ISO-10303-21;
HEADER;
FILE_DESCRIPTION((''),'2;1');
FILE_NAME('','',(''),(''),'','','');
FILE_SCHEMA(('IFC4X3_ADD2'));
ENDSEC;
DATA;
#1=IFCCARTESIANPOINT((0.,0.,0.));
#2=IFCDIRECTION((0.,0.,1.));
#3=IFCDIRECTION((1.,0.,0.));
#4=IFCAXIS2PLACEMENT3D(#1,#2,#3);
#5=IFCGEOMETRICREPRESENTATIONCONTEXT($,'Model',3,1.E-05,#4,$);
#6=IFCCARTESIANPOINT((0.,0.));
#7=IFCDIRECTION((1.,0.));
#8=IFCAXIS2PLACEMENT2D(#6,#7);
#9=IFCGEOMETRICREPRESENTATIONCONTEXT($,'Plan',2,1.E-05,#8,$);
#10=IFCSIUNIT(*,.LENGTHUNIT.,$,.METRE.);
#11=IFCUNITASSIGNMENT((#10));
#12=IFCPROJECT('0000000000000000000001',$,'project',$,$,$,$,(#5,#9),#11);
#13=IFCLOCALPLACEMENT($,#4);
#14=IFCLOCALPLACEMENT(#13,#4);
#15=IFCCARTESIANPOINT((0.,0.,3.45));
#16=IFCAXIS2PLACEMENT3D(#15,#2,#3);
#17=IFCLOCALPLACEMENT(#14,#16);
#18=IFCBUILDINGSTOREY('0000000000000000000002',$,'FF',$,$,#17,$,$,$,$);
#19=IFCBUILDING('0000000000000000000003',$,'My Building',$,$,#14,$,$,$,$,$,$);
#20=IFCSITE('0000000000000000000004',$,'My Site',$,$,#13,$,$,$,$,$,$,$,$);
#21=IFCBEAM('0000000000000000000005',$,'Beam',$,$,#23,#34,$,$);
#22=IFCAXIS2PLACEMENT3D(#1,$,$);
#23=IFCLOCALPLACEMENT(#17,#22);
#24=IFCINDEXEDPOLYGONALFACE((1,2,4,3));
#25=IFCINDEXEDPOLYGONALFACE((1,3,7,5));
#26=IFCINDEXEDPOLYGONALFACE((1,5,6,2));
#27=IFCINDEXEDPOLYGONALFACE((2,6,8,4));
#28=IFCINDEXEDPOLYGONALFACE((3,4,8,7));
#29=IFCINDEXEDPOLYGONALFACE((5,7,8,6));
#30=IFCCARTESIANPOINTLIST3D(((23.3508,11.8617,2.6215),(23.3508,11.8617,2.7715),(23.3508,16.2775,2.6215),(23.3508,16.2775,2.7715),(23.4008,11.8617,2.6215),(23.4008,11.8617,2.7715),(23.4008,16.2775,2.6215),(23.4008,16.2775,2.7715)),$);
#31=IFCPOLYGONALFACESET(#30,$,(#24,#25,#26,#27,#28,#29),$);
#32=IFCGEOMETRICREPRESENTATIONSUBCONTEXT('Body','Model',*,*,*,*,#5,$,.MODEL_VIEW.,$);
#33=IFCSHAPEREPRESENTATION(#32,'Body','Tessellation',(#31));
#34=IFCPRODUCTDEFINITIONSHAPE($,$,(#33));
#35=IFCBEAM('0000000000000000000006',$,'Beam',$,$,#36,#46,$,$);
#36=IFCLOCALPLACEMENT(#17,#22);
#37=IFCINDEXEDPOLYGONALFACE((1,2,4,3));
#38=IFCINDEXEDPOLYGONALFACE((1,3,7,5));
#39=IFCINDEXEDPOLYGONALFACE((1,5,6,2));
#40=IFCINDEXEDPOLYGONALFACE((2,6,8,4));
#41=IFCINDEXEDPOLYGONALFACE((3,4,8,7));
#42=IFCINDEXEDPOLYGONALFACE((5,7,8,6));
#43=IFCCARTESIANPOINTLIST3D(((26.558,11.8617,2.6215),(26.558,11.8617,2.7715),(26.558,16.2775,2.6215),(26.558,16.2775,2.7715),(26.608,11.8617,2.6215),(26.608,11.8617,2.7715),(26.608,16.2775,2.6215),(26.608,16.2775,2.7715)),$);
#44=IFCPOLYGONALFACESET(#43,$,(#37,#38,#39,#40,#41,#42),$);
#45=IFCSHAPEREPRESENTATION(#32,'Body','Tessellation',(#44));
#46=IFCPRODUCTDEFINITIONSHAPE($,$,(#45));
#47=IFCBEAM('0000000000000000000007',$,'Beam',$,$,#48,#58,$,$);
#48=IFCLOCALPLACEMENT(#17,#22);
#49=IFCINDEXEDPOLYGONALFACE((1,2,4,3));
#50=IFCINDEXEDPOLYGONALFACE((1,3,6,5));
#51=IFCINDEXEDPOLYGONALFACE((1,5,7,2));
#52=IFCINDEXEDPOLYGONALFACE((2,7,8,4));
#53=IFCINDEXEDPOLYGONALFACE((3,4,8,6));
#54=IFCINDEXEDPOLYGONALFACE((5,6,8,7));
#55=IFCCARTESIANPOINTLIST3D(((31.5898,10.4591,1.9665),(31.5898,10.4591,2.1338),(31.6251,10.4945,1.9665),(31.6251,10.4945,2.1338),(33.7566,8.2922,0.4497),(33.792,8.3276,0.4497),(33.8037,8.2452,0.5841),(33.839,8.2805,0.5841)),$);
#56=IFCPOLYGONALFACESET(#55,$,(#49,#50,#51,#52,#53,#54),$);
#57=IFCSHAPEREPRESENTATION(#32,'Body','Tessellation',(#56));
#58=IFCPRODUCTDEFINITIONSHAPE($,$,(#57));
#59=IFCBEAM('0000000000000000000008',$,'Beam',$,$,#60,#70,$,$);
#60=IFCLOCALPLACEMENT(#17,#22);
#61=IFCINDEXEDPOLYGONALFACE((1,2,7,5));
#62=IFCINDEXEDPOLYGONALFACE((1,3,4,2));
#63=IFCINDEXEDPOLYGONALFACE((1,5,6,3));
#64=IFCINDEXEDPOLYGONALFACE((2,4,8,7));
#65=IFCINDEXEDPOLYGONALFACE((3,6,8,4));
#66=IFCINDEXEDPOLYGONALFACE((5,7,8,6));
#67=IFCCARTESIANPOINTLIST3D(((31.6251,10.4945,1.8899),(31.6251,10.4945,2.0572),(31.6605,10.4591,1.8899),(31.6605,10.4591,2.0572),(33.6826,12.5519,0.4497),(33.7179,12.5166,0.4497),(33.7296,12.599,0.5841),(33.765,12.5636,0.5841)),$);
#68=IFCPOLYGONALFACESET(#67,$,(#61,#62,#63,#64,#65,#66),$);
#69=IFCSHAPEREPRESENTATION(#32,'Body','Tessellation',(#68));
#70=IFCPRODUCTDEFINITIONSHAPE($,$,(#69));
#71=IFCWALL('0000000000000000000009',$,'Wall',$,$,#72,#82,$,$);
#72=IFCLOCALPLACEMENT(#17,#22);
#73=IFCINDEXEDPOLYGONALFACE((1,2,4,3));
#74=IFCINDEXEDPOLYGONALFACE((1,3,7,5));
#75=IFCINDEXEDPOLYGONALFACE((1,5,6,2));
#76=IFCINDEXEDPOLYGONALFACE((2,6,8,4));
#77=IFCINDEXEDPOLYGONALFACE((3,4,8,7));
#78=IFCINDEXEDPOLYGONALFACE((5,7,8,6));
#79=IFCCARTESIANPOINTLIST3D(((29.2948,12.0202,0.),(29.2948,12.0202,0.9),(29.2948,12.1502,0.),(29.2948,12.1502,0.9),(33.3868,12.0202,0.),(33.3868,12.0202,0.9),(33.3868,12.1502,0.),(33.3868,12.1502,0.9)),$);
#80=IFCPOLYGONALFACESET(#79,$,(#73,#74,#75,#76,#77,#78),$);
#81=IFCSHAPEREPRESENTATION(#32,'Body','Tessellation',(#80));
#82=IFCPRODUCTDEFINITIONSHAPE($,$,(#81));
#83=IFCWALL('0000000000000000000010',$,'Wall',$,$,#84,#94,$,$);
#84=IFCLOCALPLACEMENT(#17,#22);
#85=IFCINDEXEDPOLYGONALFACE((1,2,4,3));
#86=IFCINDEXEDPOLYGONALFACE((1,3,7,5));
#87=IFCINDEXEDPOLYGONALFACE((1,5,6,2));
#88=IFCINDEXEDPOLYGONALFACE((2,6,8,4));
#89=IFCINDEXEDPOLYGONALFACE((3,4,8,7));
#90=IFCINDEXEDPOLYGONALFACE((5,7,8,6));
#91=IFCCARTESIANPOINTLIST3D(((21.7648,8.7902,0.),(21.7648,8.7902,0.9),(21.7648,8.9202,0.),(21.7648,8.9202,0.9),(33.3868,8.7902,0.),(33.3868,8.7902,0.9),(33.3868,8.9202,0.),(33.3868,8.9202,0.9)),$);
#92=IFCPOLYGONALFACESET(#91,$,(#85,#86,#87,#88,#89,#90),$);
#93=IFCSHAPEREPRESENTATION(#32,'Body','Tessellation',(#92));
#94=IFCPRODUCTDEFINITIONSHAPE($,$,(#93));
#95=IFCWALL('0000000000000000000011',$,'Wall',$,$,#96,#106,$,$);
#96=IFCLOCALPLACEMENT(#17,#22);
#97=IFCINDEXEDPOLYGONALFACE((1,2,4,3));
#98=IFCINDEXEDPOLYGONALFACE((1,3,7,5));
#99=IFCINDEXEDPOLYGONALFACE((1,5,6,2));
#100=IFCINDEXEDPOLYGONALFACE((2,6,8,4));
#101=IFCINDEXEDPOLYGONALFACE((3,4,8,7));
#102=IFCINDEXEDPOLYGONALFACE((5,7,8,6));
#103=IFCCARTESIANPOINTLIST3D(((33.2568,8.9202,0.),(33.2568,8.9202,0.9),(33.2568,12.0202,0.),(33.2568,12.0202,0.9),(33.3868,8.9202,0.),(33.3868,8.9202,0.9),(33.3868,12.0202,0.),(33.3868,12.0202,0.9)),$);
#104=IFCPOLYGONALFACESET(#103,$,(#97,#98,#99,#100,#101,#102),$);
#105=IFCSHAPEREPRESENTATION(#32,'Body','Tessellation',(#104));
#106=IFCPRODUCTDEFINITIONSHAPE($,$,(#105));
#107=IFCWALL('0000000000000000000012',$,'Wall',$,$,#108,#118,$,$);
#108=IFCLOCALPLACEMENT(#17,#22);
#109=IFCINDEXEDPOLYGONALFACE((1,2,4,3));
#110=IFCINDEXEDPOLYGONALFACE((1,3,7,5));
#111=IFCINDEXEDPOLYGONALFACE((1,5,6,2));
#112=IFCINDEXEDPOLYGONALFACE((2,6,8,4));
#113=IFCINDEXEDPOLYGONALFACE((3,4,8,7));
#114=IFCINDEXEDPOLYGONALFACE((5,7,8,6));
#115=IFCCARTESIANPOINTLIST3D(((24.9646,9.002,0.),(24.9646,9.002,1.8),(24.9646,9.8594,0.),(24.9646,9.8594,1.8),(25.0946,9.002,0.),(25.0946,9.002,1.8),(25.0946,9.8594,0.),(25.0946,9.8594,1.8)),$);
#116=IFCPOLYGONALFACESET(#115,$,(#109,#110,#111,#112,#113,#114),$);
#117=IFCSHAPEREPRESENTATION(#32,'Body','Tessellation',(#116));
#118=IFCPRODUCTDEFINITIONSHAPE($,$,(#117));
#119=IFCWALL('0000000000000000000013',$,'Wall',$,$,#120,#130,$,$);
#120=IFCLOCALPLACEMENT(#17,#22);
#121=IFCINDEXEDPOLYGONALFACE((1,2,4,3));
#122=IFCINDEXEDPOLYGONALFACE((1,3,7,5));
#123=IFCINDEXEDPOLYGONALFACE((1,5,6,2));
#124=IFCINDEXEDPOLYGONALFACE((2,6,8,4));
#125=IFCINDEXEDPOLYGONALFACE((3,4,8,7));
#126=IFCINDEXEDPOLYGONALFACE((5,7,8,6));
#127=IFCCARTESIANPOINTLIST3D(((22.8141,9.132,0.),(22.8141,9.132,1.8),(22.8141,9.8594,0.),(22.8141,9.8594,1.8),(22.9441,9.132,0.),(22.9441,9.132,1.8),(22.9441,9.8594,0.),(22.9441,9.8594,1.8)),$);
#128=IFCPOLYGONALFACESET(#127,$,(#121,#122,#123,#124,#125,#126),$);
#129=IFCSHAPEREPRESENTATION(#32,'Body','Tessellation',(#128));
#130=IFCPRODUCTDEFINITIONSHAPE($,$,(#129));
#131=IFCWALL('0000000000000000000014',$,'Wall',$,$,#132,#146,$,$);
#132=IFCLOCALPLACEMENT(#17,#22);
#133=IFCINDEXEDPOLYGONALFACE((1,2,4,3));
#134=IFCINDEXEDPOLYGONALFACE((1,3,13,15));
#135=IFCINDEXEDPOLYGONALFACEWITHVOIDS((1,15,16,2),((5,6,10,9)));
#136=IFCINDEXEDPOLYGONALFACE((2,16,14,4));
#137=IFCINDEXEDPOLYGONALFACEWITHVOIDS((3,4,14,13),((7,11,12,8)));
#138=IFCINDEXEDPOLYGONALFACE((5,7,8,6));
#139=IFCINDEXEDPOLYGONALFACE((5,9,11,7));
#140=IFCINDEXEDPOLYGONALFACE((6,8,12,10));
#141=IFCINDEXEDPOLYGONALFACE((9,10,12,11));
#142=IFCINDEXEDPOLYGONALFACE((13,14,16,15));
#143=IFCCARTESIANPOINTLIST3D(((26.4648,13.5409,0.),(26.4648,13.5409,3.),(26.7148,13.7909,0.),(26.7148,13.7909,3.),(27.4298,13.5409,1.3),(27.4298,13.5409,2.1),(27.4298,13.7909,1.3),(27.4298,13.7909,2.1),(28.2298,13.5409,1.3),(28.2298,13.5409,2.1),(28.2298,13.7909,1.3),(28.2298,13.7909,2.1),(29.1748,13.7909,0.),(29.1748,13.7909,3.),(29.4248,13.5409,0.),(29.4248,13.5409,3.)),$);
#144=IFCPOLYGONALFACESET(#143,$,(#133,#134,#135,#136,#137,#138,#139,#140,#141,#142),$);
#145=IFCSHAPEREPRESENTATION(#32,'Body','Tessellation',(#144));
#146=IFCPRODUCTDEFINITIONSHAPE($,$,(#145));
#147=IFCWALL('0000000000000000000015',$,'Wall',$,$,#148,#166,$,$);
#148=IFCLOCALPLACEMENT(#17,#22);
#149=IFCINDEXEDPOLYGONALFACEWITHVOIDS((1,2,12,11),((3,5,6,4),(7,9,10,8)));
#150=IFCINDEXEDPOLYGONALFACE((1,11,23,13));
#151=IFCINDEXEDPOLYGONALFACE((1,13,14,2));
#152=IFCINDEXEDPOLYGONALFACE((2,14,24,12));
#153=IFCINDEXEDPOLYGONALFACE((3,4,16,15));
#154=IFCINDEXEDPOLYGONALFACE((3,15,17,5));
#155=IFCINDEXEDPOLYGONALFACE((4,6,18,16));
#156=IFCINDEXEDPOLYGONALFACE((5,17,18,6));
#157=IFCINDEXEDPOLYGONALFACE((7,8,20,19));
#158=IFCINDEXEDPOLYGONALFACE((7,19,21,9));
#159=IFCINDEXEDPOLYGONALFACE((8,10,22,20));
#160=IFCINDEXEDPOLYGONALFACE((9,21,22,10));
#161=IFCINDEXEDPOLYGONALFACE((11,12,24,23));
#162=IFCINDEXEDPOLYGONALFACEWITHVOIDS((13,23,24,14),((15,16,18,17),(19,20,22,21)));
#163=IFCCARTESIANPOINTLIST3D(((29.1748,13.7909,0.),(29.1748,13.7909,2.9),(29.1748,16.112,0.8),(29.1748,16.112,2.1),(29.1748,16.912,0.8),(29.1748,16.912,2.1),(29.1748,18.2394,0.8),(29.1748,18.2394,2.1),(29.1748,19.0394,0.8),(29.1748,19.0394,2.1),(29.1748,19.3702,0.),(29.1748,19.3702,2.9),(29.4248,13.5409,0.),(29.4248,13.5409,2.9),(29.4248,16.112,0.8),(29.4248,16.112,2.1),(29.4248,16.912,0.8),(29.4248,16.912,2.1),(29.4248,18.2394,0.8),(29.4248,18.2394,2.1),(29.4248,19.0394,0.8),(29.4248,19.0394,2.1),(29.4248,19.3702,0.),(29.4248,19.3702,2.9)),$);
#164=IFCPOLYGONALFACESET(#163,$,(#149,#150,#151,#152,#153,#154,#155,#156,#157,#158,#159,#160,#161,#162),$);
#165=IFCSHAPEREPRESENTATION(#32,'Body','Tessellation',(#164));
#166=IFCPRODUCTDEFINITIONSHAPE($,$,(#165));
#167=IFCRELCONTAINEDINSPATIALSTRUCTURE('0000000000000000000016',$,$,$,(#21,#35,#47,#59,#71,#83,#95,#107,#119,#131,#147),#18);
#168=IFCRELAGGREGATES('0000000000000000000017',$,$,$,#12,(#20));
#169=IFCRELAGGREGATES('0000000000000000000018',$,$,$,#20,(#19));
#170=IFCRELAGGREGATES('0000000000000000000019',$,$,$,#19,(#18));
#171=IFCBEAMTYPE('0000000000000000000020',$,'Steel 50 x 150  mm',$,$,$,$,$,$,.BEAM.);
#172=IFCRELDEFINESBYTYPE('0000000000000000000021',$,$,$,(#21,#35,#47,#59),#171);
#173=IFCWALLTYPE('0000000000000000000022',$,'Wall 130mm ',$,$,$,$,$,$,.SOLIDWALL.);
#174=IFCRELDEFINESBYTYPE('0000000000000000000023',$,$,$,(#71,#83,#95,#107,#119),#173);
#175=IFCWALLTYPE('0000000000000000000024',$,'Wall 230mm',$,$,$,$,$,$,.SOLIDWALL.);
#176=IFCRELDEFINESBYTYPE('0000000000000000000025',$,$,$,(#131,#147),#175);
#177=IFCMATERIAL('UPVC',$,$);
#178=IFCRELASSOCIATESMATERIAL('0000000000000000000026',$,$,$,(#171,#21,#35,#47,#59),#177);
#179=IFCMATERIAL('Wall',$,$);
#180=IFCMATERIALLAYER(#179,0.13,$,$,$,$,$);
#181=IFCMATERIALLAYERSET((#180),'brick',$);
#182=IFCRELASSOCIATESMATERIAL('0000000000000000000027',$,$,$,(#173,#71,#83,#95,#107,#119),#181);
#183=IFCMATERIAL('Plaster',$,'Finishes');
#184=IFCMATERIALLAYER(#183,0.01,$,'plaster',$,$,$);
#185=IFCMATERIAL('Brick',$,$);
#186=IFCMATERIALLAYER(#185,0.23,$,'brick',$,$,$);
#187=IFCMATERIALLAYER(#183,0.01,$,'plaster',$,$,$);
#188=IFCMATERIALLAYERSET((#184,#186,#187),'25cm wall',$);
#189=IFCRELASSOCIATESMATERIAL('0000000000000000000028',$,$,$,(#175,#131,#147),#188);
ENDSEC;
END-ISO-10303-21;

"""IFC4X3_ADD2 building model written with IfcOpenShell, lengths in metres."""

from ifc_helpers import new_model, si_unit, frame, origin_with_axes, origin_2d_with_axis, place, context, subcontext, project, spatial, line, indexed_curve, rectangle, outline, extrude, clip, halfspace, source, transform, mapped, material, layer, layer_set, layer_usage, material_profile, profile_set, profile_usage, type_object, element, save


model = new_model("IFC4X3_ADD2")

# Units and contexts
model_context = context("Model", 3, precision=1e-05, world=origin_with_axes())
plan_context = context("Plan", 2, precision=1e-05, world=origin_2d_with_axis())
body_context_1 = subcontext(model_context, "Body", "Model", "MODEL_VIEW")
ifc_project = project(units=[si_unit("LENGTHUNIT", "METRE")], contexts=[model_context, plan_context])

# Site, building, storey
site_placement = place(None, origin_with_axes())
site = spatial("IfcSite", under=ifc_project, at=site_placement, Name="My Site")
building_placement = place(site_placement, origin_with_axes())
building = spatial("IfcBuilding", under=site, at=building_placement, Name="My Building")
storey_placement = place(building_placement, frame((0.0, 0.0, 3.45), z_axis=(0.0, 0.0, 1.0), x_axis=(1.0, 0.0, 0.0)))
storey = spatial("IfcBuildingStorey", under=building, at=storey_placement, Name="FF")

# Beams
ifc_material_1 = material(Name="UPVC")
ifc_material_profile = material_profile(ifc_material_1, rectangle(XDim=0.05, YDim=0.15))
ifc_profile_set = profile_set([ifc_material_profile])
ifc_profile_usage_1 = profile_usage(ifc_profile_set)
beam_type = type_object("IfcBeamType", Name="Steel 50 x 150  mm", PredefinedType="BEAM", material=ifc_profile_set)
beam_1_placement = place(storey_placement, frame((23.3758, 11.8617, 2.6965), z_axis=(0.0, 1.0, 0.0), x_axis=(-1.0, 0.0, 0.0)))
element("IfcBeam", 1, at=beam_1_placement, inside=storey, type_object=beam_type, material=ifc_profile_usage_1, Name="Beam", context=body_context_1, shape_type="SweptSolid", body=[
    extrude(rectangle(XDim=0.05, YDim=0.15), origin_with_axes(), (0.0, 0.0, 1.0), 4.4158),
])
ifc_profile_usage_2 = profile_usage(ifc_profile_set)
beam_2_placement = place(storey_placement, frame((26.583, 11.8617, 2.6965), z_axis=(0.0, 1.0, 0.0), x_axis=(-1.0, 0.0, 0.0)))
element("IfcBeam", 2, at=beam_2_placement, inside=storey, type_object=beam_type, material=ifc_profile_usage_2, Name="Beam", context=body_context_1, shape_type="SweptSolid", body=[
    extrude(rectangle(XDim=0.05, YDim=0.15), origin_with_axes(), (0.0, 0.0, 1.0), 4.4158),
])
ifc_profile_usage_3 = profile_usage(ifc_profile_set)
beam_3_placement = place(storey_placement, frame((33.7978, 8.2864, 0.5169), z_axis=(-0.633729, 0.633729, 0.443593), x_axis=(-0.707107, -0.707107, 0.0)))
element("IfcBeam", 3, at=beam_3_placement, inside=storey, type_object=beam_type, material=ifc_profile_usage_3, Name="Beam", context=body_context_1, shape_type="Clipping", body=[
    clip(extrude(rectangle(XDim=0.05, YDim=0.15), origin_with_axes(), (0.0, 0.0, 1.0), 3.6064), halfspace(frame((-2.9679, -1.3741, 2.7762), z_axis=(0.0, -0.443593, 0.896228), x_axis=(-1.0, -0.000001, 0.0)), False)),
])
ifc_profile_usage_4 = profile_usage(ifc_profile_set)
beam_4_placement = place(storey_placement, frame((33.7238, 12.5578, 0.5169), z_axis=(-0.633729, -0.633729, 0.443593), x_axis=(0.707107, -0.707107, 0.0)))
element("IfcBeam", 4, at=beam_4_placement, inside=storey, type_object=beam_type, material=ifc_profile_usage_4, Name="Beam", context=body_context_1, shape_type="Clipping", body=[
    clip(extrude(rectangle(XDim=0.05, YDim=0.15), origin_with_axes(), (0.0, 0.0, 1.0), 3.4337), halfspace(frame((3.0727, -1.3055, 2.6376), z_axis=(0.0, -0.443593, 0.896228), x_axis=(-1.0, 0.0, 0.0)), False)),
])

# Walls
ifc_material_2 = material(Name="Wall")
ifc_layer_1 = layer(ifc_material_2, 0.13)
ifc_layer_set_1 = layer_set([ifc_layer_1], Name="brick")
ifc_layer_usage_1 = layer_usage(ifc_layer_set_1, "AXIS2", "POSITIVE", 0.0)
wall_type_1 = type_object("IfcWallType", Name="Wall 130mm ", PredefinedType="SOLIDWALL", material=ifc_layer_set_1)
wall_1_placement = place(storey_placement, frame((33.3868, 12.1502, 0.0), z_axis=(0.0, 0.0, 1.0), x_axis=(-1.0, 0.0, 0.0)))
element("IfcWall", 5, at=wall_1_placement, inside=storey, type_object=wall_type_1, material=ifc_layer_usage_1, Name="Wall", context=body_context_1, shape_type="SweptSolid", body=[
    extrude(outline(indexed_curve([(0.0, 0.0), (0.0, 0.13), (4.092, 0.13), (4.092, 0.0), (0.0, 0.0)], self_intersect=False)), origin_with_axes(), (0.0, 0.0, 1.0), 0.9),
])
ifc_layer_usage_2 = layer_usage(ifc_layer_set_1, "AXIS2", "POSITIVE", 0.0)
wall_2_placement = place(storey_placement, frame((33.3868, 8.9202, 0.0), z_axis=(0.0, 0.0, 1.0), x_axis=(-1.0, 0.0, 0.0)))
element("IfcWall", 6, at=wall_2_placement, inside=storey, type_object=wall_type_1, material=ifc_layer_usage_2, Name="Wall", context=body_context_1, shape_type="SweptSolid", body=[
    extrude(outline(indexed_curve([(0.0, 0.0), (0.0, 0.13), (11.622, 0.13), (11.622, 0.0), (0.0, 0.0)], self_intersect=False)), origin_with_axes(), (0.0, 0.0, 1.0), 0.9),
])
ifc_layer_usage_3 = layer_usage(ifc_layer_set_1, "AXIS2", "POSITIVE", 0.0)
wall_3_placement = place(storey_placement, frame((33.2568, 12.0202, 0.0), z_axis=(0.0, 0.0, 1.0), x_axis=(0.0, -1.0, 0.0)))
element("IfcWall", 7, at=wall_3_placement, inside=storey, type_object=wall_type_1, material=ifc_layer_usage_3, Name="Wall", context=body_context_1, shape_type="SweptSolid", body=[
    extrude(outline(indexed_curve([(0.0, 0.0), (0.0, 0.13), (3.1, 0.13), (3.1, 0.0), (0.0, 0.0)], self_intersect=False)), origin_with_axes(), (0.0, 0.0, 1.0), 0.9),
])
ifc_layer_usage_4 = layer_usage(ifc_layer_set_1, "AXIS2", "POSITIVE", 0.0)
wall_4_placement = place(storey_placement, frame((25.0946, 9.002, 0.0), z_axis=(0.0, 0.0, 1.0), x_axis=(0.0, 1.0, 0.0)))
element("IfcWall", 8, at=wall_4_placement, inside=storey, type_object=wall_type_1, material=ifc_layer_usage_4, Name="Wall", context=body_context_1, shape_type="SweptSolid", body=[
    extrude(outline(indexed_curve([(0.0, 0.0), (0.0, 0.13), (0.8574, 0.13), (0.8574, 0.0), (0.0, 0.0)], self_intersect=False)), origin_with_axes(), (0.0, 0.0, 1.0), 1.8),
])
ifc_layer_usage_5 = layer_usage(ifc_layer_set_1, "AXIS2", "POSITIVE", 0.0)
wall_5_placement = place(storey_placement, frame((22.9441, 9.132, 0.0), z_axis=(0.0, 0.0, 1.0), x_axis=(0.0, 1.0, 0.0)))
element("IfcWall", 9, at=wall_5_placement, inside=storey, type_object=wall_type_1, material=ifc_layer_usage_5, Name="Wall", context=body_context_1, shape_type="SweptSolid", body=[
    extrude(outline(indexed_curve([(0.0, 0.0), (0.0, 0.13), (0.7274, 0.13), (0.7274, 0.0), (0.0, 0.0)], self_intersect=False)), origin_with_axes(), (0.0, 0.0, 1.0), 1.8),
])

# Wall, opening
ifc_material_3 = material(Name="Plaster", Category="Finishes")
ifc_layer_2 = layer(ifc_material_3, 0.01, Name="plaster")
ifc_material_4 = material(Name="Brick")
ifc_layer_3 = layer(ifc_material_4, 0.23, Name="brick")
ifc_layer_4 = layer(ifc_material_3, 0.01, Name="plaster")
ifc_layer_set_2 = layer_set([ifc_layer_2, ifc_layer_3, ifc_layer_4], Name="25cm wall")
ifc_layer_usage_6 = layer_usage(ifc_layer_set_2, "AXIS2", "NEGATIVE", 0.0)
wall_type_2 = type_object("IfcWallType", Name="Wall 230mm", PredefinedType="SOLIDWALL", material=ifc_layer_set_2)
wall_6_placement = place(storey_placement, frame((29.4248, 13.5409, 0.0), z_axis=(0.0, 0.0, 1.0), x_axis=(-1.0, 0.0, 0.0)))
wall_6 = element("IfcWall", 10, at=wall_6_placement, inside=storey, type_object=wall_type_2, material=ifc_layer_usage_6, Name="Wall", context=body_context_1, shape_type="SweptSolid", body=[
    extrude(outline(indexed_curve([(0.25, -0.25), (0.0, 0.0), (2.96, 0.0), (2.71, -0.25)], segments=[line(1, 2, 3, 4, 1)])), origin_with_axes(), (0.0, 0.0, 1.0), 3.0),
])
shared_shape_1 = source(origin_with_axes(), body_context_1, "Body", "SweptSolid", [
    extrude(outline(indexed_curve([(0.0, 0.0), (0.8, 0.0), (0.8, 0.8), (0.0, 0.8)], segments=[line(1, 2, 3, 4, 1)])), frame((-0.4, -0.6, 0.0), z_axis=(0.0, -1.0, 0.0), x_axis=(1.0, 0.0, 0.0)), (0.0, 0.0, -1.0), 1.2),
])
opening_1_placement = place(wall_6_placement, frame((1.595, 0.0, 1.3), z_axis=(0.0, 0.0, 1.0), x_axis=(1.0, 0.0, 0.0)))
element("IfcOpeningElement", 11, at=opening_1_placement, cuts=wall_6, PredefinedType="OPENING", context=body_context_1, shape_type="MappedRepresentation", body=[
    mapped(shared_shape_1, transform((0.0, 0.0, 0.0), x_axis=(1.0, 0.0, 0.0), y_axis=(0.0, 1.0, 0.0), z_axis=(0.0, 0.0, 1.0), scale=1.0)),
])

# Wall, openings
ifc_layer_usage_7 = layer_usage(ifc_layer_set_2, "AXIS2", "POSITIVE", 0.0)
wall_7_placement = place(storey_placement, frame((29.4248, 13.5409, 0.0), z_axis=(0.0, 0.0, 1.0), x_axis=(0.000001, 1.0, 0.0)))
wall_7 = element("IfcWall", 12, at=wall_7_placement, inside=storey, type_object=wall_type_2, material=ifc_layer_usage_7, Name="Wall", context=body_context_1, shape_type="SweptSolid", body=[
    extrude(outline(indexed_curve([(0.0, 0.0), (0.25, 0.25), (5.8293, 0.25), (5.8293, 0.0)], segments=[line(1, 2, 3, 4, 1)])), origin_with_axes(), (0.0, 0.0, 1.0), 2.9),
])
shared_shape_2 = source(origin_with_axes(), body_context_1, "Body", "SweptSolid", [
    extrude(outline(indexed_curve([(0.0, 0.0), (0.8, 0.0), (0.8, 1.3), (0.0, 1.3)], segments=[line(1, 2, 3, 4, 1)])), frame((-0.4, -0.6, 0.0), z_axis=(0.0, -1.0, 0.0), x_axis=(1.0, 0.0, 0.0)), (0.0, 0.0, -1.0), 1.2),
])
opening_2_placement = place(wall_7_placement, frame((2.9711, 0.0, 0.8), z_axis=(0.0, 0.0, 1.0), x_axis=(1.0, 0.0, 0.0)))
element("IfcOpeningElement", 13, at=opening_2_placement, cuts=wall_7, PredefinedType="OPENING", context=body_context_1, shape_type="MappedRepresentation", body=[
    mapped(shared_shape_2, transform((0.0, 0.0, 0.0), x_axis=(1.0, 0.0, 0.0), y_axis=(0.0, 1.0, 0.0), z_axis=(0.0, 0.0, 1.0), scale=1.0)),
])
opening_3_placement = place(wall_7_placement, frame((5.0985, 0.0, 0.8), z_axis=(0.0, 0.0, 1.0), x_axis=(1.0, 0.0, 0.0)))
element("IfcOpeningElement", 14, at=opening_3_placement, cuts=wall_7, PredefinedType="OPENING", context=body_context_1, shape_type="MappedRepresentation", body=[
    mapped(shared_shape_2, transform((0.0, 0.0, 0.0), x_axis=(1.0, 0.0, 0.0), y_axis=(0.0, 1.0, 0.0), z_axis=(0.0, 0.0, 1.0), scale=1.0)),
])

save(model, "model.ifc")
